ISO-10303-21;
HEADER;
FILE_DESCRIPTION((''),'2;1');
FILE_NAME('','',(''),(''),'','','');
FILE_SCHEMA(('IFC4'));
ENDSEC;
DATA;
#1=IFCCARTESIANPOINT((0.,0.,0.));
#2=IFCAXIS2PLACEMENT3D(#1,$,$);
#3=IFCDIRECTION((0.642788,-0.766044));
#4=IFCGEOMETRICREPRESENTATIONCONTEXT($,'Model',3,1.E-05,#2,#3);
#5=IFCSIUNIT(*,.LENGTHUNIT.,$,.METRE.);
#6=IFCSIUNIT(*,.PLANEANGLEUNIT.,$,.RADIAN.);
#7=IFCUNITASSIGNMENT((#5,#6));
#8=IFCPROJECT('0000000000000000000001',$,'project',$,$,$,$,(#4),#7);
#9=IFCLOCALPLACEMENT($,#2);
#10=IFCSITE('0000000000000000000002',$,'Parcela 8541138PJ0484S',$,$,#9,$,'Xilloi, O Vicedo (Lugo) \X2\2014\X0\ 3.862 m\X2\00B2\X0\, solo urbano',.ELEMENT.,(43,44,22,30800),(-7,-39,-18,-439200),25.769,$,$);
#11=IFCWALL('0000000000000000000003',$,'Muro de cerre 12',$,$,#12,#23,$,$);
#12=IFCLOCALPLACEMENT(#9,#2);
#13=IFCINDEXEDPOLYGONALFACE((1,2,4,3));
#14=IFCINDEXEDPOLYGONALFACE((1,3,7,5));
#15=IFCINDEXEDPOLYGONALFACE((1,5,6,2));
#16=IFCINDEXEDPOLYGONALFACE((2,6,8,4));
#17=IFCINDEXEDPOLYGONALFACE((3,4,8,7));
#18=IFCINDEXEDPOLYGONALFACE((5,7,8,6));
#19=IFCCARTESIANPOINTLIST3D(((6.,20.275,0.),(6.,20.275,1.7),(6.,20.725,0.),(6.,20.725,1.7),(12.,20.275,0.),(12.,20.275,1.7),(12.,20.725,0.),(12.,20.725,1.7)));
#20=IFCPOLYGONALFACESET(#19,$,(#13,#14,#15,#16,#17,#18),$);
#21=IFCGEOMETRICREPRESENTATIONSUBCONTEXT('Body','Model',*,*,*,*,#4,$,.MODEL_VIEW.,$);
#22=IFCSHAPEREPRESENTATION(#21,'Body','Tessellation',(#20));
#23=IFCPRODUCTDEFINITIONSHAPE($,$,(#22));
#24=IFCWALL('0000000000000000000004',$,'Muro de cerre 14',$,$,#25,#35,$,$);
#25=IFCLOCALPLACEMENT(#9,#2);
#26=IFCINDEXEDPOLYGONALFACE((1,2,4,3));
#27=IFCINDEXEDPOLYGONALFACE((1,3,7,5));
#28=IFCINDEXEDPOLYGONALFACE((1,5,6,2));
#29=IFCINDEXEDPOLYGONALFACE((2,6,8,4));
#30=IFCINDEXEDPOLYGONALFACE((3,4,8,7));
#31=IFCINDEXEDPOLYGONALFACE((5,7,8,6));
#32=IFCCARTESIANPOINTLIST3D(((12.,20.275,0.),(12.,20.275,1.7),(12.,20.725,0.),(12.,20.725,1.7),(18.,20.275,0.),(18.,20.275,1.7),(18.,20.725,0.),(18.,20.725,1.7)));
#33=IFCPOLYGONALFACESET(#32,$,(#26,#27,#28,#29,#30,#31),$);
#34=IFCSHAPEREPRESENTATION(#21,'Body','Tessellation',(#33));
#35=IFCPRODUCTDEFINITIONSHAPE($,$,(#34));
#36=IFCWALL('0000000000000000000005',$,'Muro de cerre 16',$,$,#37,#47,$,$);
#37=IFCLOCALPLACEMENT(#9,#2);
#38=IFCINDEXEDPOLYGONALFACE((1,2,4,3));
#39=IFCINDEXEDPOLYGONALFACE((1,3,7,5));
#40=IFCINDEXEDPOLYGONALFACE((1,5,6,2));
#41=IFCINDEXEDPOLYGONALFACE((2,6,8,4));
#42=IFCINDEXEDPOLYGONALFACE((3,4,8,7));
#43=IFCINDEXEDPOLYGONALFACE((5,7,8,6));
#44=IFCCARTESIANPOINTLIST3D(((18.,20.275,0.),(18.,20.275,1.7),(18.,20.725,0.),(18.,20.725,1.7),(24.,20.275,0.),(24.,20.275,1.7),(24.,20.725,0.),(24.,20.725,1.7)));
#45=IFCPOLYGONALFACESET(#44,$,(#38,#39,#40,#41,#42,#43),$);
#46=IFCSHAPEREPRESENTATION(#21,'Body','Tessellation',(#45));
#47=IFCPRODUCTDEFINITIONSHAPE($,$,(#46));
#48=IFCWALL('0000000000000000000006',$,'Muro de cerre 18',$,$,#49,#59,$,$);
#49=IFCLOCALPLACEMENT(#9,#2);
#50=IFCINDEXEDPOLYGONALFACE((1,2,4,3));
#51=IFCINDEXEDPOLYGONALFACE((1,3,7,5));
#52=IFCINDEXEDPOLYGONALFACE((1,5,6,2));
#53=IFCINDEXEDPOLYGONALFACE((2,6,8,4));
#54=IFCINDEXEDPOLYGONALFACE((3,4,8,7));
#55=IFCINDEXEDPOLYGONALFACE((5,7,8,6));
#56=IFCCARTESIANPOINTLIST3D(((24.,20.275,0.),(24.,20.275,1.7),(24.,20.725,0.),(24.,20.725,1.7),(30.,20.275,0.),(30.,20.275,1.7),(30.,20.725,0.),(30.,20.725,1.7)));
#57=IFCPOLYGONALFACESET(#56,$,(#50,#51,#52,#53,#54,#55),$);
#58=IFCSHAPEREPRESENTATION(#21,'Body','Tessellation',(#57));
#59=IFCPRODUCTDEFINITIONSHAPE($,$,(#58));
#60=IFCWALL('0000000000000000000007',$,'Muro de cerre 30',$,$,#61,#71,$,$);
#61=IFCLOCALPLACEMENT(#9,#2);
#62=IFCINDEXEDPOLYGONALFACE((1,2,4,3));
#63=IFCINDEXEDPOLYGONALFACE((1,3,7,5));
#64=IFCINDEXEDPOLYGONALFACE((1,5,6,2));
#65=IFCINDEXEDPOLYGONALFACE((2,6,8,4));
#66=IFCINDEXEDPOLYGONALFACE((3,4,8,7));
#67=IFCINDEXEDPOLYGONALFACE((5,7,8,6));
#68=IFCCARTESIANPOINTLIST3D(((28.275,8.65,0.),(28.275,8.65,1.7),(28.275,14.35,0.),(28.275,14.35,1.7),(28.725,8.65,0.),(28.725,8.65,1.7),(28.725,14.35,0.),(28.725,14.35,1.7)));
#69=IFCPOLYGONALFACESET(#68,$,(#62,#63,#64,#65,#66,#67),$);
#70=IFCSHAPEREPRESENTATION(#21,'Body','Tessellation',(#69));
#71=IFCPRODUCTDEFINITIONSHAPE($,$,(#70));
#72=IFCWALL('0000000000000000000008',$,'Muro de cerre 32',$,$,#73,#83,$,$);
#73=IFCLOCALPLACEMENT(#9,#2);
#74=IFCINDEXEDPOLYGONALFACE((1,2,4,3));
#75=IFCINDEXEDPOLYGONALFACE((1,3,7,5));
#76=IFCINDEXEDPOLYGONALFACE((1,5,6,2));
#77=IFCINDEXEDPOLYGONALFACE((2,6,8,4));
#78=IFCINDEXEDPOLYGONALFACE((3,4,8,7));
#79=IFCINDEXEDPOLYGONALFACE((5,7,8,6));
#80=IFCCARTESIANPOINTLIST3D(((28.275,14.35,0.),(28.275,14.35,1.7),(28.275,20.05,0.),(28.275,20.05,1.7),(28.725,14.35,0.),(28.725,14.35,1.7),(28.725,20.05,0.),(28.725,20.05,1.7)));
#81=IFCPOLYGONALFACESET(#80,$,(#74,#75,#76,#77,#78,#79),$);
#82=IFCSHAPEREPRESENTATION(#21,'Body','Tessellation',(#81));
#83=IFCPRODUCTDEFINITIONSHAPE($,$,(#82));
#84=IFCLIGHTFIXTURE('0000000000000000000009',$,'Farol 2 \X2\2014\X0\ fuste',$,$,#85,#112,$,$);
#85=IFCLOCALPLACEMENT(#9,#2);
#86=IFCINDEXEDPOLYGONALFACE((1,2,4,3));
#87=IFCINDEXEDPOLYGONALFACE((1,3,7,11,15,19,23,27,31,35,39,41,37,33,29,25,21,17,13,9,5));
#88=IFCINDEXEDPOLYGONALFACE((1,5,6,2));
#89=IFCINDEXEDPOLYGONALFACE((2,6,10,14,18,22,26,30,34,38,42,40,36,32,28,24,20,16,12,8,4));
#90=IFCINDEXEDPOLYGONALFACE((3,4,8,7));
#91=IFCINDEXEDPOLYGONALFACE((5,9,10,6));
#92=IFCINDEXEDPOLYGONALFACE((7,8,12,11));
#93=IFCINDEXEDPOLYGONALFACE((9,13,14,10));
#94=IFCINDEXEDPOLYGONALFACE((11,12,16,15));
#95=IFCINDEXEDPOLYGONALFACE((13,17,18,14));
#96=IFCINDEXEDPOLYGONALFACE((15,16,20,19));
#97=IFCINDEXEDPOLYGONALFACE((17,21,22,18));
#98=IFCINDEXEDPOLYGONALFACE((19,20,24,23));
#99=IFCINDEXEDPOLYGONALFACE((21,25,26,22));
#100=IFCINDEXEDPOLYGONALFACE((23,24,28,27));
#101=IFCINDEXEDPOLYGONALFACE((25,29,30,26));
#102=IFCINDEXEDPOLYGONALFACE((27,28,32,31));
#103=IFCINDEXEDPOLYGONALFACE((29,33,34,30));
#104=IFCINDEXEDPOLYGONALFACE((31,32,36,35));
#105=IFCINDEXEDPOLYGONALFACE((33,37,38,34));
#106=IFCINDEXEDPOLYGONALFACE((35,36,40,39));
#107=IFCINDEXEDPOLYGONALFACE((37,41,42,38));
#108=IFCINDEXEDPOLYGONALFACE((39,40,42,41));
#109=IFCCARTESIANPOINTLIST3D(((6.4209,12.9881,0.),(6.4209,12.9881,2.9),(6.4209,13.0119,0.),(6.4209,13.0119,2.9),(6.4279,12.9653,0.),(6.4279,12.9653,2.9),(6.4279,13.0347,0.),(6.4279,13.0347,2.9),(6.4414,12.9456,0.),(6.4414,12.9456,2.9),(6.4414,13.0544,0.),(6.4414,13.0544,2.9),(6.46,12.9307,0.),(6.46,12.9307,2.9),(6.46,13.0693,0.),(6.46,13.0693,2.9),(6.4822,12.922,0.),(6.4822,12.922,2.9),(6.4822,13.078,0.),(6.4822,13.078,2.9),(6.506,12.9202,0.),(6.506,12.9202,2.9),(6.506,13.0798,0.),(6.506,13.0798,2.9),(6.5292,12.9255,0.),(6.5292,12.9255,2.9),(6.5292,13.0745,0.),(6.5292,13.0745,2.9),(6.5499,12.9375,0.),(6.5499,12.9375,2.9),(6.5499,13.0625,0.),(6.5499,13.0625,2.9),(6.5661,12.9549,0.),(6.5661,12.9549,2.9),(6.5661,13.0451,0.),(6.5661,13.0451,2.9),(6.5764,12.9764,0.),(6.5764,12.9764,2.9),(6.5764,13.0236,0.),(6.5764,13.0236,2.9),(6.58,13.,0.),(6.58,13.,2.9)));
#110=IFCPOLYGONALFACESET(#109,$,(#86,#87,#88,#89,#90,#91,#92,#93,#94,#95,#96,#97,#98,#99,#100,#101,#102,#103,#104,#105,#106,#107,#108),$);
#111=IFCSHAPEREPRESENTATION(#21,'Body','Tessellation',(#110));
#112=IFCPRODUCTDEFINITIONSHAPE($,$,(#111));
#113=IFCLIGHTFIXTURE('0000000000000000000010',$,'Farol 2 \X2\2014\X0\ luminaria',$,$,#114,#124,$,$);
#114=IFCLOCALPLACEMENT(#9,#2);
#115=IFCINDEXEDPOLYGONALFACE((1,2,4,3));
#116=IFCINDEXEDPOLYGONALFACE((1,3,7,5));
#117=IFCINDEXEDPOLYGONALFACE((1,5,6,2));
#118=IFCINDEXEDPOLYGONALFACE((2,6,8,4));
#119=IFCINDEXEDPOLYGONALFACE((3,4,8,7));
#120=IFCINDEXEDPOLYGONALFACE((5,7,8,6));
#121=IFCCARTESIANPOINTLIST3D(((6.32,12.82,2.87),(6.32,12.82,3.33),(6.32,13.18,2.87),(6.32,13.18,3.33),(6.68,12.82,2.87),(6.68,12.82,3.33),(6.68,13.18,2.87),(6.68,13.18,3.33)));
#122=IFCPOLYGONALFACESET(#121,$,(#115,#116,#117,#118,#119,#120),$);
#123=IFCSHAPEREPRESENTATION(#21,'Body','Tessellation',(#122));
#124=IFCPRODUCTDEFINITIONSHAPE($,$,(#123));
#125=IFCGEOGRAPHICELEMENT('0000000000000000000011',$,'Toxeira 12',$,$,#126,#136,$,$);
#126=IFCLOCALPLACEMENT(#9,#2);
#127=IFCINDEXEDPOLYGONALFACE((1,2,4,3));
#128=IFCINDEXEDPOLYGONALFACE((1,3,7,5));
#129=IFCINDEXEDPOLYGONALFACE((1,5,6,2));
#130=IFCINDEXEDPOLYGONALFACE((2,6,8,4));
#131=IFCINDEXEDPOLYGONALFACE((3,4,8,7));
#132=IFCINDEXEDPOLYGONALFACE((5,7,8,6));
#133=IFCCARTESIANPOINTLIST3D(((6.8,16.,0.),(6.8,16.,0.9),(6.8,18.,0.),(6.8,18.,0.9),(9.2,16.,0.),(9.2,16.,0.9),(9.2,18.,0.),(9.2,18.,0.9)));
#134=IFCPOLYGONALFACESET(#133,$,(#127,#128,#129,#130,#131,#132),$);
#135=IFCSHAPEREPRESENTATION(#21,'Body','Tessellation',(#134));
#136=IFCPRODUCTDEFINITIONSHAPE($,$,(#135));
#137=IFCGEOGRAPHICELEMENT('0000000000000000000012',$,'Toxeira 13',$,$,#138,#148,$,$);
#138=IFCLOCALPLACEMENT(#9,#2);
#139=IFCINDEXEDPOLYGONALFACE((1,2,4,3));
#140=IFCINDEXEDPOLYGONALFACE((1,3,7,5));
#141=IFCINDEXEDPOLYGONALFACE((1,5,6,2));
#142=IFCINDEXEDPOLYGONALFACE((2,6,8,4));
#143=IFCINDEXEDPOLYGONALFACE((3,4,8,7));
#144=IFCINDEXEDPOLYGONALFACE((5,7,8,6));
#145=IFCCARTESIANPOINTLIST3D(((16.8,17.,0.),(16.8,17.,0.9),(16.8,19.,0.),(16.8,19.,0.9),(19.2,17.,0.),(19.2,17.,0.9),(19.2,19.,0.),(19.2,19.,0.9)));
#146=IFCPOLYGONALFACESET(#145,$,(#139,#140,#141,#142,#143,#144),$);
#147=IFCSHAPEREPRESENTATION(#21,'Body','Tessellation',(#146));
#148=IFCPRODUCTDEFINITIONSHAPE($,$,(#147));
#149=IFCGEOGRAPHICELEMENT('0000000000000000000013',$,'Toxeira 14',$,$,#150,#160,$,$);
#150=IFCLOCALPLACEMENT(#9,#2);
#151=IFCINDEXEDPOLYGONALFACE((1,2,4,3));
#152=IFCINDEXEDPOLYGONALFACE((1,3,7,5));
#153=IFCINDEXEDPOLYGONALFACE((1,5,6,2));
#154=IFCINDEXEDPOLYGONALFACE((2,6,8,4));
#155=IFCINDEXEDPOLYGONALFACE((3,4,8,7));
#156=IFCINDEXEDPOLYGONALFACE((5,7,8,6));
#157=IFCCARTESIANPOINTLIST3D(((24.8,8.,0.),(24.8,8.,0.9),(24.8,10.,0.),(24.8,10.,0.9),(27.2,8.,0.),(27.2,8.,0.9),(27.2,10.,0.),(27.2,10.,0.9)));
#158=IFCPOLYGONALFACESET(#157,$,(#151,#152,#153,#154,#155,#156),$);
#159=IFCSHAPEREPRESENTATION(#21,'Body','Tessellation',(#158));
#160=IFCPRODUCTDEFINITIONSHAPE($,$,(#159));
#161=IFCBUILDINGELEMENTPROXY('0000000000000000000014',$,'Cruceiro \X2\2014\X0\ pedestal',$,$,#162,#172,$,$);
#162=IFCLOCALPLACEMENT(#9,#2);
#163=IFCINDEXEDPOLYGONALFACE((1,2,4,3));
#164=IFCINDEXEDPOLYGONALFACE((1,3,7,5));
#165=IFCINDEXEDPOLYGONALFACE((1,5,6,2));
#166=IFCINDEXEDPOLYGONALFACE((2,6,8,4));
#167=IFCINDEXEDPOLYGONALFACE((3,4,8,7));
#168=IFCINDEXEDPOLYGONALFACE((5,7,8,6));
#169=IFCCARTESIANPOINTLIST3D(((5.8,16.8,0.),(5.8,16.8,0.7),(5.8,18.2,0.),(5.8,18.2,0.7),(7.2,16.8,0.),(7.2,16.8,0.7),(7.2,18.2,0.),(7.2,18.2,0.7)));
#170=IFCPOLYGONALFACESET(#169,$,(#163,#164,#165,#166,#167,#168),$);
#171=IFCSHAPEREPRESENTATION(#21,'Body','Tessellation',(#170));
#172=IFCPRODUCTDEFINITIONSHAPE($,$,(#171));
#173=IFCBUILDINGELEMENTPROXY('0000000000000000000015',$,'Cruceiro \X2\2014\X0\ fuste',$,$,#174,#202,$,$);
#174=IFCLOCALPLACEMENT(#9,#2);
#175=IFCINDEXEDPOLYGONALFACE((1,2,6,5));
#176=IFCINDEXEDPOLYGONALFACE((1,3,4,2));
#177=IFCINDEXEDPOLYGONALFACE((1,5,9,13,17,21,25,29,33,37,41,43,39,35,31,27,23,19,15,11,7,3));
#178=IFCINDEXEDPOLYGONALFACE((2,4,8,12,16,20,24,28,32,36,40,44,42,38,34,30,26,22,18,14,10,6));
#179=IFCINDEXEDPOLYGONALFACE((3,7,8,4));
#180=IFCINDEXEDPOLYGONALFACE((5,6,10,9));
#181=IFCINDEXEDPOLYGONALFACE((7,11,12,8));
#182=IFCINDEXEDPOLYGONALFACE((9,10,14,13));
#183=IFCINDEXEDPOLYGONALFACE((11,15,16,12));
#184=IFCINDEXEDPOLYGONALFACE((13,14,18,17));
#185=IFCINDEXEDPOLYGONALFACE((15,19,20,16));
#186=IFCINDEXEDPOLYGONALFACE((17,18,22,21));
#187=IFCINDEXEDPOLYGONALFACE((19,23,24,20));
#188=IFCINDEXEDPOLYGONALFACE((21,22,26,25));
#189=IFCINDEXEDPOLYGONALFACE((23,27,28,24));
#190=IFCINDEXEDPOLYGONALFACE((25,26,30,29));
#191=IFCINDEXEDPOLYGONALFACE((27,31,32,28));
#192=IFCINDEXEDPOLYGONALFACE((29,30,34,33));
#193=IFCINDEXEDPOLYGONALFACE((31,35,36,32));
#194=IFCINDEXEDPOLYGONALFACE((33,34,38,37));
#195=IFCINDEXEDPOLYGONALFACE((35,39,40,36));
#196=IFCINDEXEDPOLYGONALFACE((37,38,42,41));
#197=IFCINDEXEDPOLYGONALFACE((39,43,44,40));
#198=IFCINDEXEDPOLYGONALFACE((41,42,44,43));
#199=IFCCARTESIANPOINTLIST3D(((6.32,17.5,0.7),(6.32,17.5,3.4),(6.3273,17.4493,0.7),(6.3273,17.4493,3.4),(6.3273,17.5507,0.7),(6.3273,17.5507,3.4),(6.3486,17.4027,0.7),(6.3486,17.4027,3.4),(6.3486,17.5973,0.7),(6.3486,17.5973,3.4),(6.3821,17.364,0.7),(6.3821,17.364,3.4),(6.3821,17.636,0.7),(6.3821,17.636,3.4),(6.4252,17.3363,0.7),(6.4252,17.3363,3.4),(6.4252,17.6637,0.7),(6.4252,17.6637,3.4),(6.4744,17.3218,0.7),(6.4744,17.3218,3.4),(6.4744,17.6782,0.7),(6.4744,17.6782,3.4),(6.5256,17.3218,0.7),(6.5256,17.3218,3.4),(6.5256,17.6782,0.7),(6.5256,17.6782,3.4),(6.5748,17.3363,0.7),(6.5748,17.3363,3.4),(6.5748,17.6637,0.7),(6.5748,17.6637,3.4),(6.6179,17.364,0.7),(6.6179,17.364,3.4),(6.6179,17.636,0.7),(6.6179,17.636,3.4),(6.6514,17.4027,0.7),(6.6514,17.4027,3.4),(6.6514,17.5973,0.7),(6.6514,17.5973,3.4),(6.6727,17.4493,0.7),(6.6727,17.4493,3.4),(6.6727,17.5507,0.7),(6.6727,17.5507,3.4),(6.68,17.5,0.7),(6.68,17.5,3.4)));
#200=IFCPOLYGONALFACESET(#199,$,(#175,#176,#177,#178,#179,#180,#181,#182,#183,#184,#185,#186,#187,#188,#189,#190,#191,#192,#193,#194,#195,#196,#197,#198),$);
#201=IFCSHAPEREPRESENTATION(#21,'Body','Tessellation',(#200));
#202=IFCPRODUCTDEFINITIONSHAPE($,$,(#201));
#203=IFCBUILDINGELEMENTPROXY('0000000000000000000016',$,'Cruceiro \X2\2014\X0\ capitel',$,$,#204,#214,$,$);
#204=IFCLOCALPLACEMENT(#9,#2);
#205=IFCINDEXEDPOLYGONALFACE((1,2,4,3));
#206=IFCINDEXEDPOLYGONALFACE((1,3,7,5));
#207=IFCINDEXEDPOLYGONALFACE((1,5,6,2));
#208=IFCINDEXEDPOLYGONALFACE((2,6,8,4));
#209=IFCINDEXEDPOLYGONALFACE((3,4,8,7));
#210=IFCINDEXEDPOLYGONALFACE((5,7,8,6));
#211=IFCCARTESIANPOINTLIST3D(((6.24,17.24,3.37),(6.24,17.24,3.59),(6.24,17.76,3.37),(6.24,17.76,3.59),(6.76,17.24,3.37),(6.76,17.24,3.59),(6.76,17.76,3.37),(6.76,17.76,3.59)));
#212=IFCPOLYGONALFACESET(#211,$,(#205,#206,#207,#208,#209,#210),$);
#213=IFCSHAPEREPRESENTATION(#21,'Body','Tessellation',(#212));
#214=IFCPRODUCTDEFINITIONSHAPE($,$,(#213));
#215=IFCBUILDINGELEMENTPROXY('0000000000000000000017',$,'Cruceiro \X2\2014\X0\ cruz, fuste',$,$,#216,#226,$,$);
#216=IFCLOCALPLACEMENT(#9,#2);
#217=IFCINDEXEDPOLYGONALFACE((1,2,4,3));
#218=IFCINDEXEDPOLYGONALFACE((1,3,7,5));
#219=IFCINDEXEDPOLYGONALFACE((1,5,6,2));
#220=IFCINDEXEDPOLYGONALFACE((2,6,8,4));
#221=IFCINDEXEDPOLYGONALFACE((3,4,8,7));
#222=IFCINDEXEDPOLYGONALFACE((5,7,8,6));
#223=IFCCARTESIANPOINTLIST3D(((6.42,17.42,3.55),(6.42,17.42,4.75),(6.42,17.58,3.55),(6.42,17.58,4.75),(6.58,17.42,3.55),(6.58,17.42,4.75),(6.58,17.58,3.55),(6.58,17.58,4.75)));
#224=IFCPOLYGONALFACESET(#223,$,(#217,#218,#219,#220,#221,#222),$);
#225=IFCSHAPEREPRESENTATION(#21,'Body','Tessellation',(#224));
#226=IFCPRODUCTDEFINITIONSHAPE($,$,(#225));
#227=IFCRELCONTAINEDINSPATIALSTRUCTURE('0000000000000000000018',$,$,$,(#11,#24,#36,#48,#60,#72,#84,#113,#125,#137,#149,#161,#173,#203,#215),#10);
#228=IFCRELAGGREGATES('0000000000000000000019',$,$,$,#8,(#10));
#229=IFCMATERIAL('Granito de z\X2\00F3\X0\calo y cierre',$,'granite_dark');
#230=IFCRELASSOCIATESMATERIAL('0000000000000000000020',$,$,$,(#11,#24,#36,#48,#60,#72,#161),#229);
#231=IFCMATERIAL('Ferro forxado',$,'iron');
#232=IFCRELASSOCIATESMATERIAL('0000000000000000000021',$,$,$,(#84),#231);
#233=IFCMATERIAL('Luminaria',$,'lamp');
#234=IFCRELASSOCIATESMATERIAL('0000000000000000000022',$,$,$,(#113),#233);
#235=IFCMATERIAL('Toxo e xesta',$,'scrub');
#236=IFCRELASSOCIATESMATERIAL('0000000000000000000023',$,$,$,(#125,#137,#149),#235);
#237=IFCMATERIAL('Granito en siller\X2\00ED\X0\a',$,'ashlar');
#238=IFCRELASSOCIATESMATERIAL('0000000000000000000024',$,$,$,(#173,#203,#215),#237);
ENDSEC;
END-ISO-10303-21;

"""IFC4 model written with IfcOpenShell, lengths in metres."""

from ifc_helpers import new_model, si_unit, direction, frame, origin, origin_2d, place, context, subcontext, project, spatial, rectangle, circle, extrude, material, element, save


model = new_model("IFC4")

# Units and contexts
model_context = context("Model", 3, precision=1e-05, world=origin(), true_north=direction((0.642788, -0.766044)))
body_context = subcontext(model_context, "Body", "Model", "MODEL_VIEW")
ifc_project = project(units=[si_unit("LENGTHUNIT", "METRE"), si_unit("PLANEANGLEUNIT", "RADIAN")], contexts=[model_context])

# Site
site_placement = place(None, origin())
site = spatial("IfcSite", under=ifc_project, at=site_placement, Name="Parcela 8541138PJ0484S", LongName="Xilloi, O Vicedo (Lugo) — 3.862 m², solo urbano", CompositionType="ELEMENT", RefLatitude=(43, 44, 22, 30800), RefLongitude=(-7, -39, -18, -439200), RefElevation=25.769)

# Walls
ifc_material_1 = material(Name="Granito de zócalo y cierre", Category="granite_dark")
for number, where, name in (
    (1, (9.0, 20.5, 0.85), "Muro de cerre 12"),
    (2, (15.0, 20.5, 0.85), "Muro de cerre 14"),
    (3, (21.0, 20.5, 0.85), "Muro de cerre 16"),
    (4, (27.0, 20.5, 0.85), "Muro de cerre 18"),
):
    element("IfcWall", number, at=place(site_placement, frame(where)), inside=site, material=ifc_material_1, Name=name, context=body_context, shape_type="SweptSolid", body=[
        extrude(rectangle(XDim=6.0, YDim=0.45, at=origin_2d()), frame((0.0, 0.0, -0.85)), (0.0, 0.0, 1.0), 1.7),
    ])
for number, where, name in (
    (5, (28.5, 11.5, 0.85), "Muro de cerre 30"),
    (6, (28.5, 17.2, 0.85), "Muro de cerre 32"),
):
    element("IfcWall", number, at=place(site_placement, frame(where)), inside=site, material=ifc_material_1, Name=name, context=body_context, shape_type="SweptSolid", body=[
        extrude(rectangle(XDim=0.45, YDim=5.7, at=origin_2d()), frame((0.0, 0.0, -0.85)), (0.0, 0.0, 1.0), 1.7),
    ])

# Light fixtures
ifc_material_2 = material(Name="Ferro forxado", Category="iron")
light_fixture_1_placement = place(site_placement, frame((6.5, 13.0, 1.45)))
element("IfcLightFixture", 7, at=light_fixture_1_placement, inside=site, material=ifc_material_2, Name="Farol 2 — fuste", context=body_context, shape_type="SweptSolid", body=[
    extrude(circle(Radius=0.08, at=origin_2d()), frame((0.0, 0.0, -1.45)), (0.0, 0.0, 1.0), 2.9),
])
ifc_material_3 = material(Name="Luminaria", Category="lamp")
light_fixture_2_placement = place(site_placement, frame((6.5, 13.0, 3.1)))
element("IfcLightFixture", 8, at=light_fixture_2_placement, inside=site, material=ifc_material_3, Name="Farol 2 — luminaria", context=body_context, shape_type="SweptSolid", body=[
    extrude(rectangle(XDim=0.36, YDim=0.36, at=origin_2d()), frame((0.0, 0.0, -0.23)), (0.0, 0.0, 1.0), 0.46),
])

# Geographic elements
ifc_material_4 = material(Name="Toxo e xesta", Category="scrub")
for number, where, name in (
    (9, (8.0, 17.0, 0.45), "Toxeira 12"),
    (10, (18.0, 18.0, 0.45), "Toxeira 13"),
    (11, (26.0, 9.0, 0.45), "Toxeira 14"),
):
    element("IfcGeographicElement", number, at=place(site_placement, frame(where)), inside=site, material=ifc_material_4, Name=name, context=body_context, shape_type="SweptSolid", body=[
        extrude(rectangle(XDim=2.4, YDim=2.0, at=origin_2d()), frame((0.0, 0.0, -0.45)), (0.0, 0.0, 1.0), 0.9),
    ])

# Building element proxies
proxy_1_placement = place(site_placement, frame((6.5, 17.5, 0.35)))
element("IfcBuildingElementProxy", 12, at=proxy_1_placement, inside=site, material=ifc_material_1, Name="Cruceiro — pedestal", context=body_context, shape_type="SweptSolid", body=[
    extrude(rectangle(XDim=1.4, YDim=1.4, at=origin_2d()), frame((0.0, 0.0, -0.35)), (0.0, 0.0, 1.0), 0.7),
])
ifc_material_5 = material(Name="Granito en sillería", Category="ashlar")
proxy_2_placement = place(site_placement, frame((6.5, 17.5, 2.05)))
element("IfcBuildingElementProxy", 13, at=proxy_2_placement, inside=site, material=ifc_material_5, Name="Cruceiro — fuste", context=body_context, shape_type="SweptSolid", body=[
    extrude(circle(Radius=0.18, at=origin_2d()), frame((0.0, 0.0, -1.35)), (0.0, 0.0, 1.0), 2.7),
])
proxy_3_placement = place(site_placement, frame((6.5, 17.5, 3.48)))
element("IfcBuildingElementProxy", 14, at=proxy_3_placement, inside=site, material=ifc_material_5, Name="Cruceiro — capitel", context=body_context, shape_type="SweptSolid", body=[
    extrude(rectangle(XDim=0.52, YDim=0.52, at=origin_2d()), frame((0.0, 0.0, -0.11)), (0.0, 0.0, 1.0), 0.22),
])
proxy_4_placement = place(site_placement, frame((6.5, 17.5, 4.15)))
element("IfcBuildingElementProxy", 15, at=proxy_4_placement, inside=site, material=ifc_material_5, Name="Cruceiro — cruz, fuste", context=body_context, shape_type="SweptSolid", body=[
    extrude(rectangle(XDim=0.16, YDim=0.16, at=origin_2d()), frame((0.0, 0.0, -0.6)), (0.0, 0.0, 1.0), 1.2),
])

save(model, "model.ifc")
